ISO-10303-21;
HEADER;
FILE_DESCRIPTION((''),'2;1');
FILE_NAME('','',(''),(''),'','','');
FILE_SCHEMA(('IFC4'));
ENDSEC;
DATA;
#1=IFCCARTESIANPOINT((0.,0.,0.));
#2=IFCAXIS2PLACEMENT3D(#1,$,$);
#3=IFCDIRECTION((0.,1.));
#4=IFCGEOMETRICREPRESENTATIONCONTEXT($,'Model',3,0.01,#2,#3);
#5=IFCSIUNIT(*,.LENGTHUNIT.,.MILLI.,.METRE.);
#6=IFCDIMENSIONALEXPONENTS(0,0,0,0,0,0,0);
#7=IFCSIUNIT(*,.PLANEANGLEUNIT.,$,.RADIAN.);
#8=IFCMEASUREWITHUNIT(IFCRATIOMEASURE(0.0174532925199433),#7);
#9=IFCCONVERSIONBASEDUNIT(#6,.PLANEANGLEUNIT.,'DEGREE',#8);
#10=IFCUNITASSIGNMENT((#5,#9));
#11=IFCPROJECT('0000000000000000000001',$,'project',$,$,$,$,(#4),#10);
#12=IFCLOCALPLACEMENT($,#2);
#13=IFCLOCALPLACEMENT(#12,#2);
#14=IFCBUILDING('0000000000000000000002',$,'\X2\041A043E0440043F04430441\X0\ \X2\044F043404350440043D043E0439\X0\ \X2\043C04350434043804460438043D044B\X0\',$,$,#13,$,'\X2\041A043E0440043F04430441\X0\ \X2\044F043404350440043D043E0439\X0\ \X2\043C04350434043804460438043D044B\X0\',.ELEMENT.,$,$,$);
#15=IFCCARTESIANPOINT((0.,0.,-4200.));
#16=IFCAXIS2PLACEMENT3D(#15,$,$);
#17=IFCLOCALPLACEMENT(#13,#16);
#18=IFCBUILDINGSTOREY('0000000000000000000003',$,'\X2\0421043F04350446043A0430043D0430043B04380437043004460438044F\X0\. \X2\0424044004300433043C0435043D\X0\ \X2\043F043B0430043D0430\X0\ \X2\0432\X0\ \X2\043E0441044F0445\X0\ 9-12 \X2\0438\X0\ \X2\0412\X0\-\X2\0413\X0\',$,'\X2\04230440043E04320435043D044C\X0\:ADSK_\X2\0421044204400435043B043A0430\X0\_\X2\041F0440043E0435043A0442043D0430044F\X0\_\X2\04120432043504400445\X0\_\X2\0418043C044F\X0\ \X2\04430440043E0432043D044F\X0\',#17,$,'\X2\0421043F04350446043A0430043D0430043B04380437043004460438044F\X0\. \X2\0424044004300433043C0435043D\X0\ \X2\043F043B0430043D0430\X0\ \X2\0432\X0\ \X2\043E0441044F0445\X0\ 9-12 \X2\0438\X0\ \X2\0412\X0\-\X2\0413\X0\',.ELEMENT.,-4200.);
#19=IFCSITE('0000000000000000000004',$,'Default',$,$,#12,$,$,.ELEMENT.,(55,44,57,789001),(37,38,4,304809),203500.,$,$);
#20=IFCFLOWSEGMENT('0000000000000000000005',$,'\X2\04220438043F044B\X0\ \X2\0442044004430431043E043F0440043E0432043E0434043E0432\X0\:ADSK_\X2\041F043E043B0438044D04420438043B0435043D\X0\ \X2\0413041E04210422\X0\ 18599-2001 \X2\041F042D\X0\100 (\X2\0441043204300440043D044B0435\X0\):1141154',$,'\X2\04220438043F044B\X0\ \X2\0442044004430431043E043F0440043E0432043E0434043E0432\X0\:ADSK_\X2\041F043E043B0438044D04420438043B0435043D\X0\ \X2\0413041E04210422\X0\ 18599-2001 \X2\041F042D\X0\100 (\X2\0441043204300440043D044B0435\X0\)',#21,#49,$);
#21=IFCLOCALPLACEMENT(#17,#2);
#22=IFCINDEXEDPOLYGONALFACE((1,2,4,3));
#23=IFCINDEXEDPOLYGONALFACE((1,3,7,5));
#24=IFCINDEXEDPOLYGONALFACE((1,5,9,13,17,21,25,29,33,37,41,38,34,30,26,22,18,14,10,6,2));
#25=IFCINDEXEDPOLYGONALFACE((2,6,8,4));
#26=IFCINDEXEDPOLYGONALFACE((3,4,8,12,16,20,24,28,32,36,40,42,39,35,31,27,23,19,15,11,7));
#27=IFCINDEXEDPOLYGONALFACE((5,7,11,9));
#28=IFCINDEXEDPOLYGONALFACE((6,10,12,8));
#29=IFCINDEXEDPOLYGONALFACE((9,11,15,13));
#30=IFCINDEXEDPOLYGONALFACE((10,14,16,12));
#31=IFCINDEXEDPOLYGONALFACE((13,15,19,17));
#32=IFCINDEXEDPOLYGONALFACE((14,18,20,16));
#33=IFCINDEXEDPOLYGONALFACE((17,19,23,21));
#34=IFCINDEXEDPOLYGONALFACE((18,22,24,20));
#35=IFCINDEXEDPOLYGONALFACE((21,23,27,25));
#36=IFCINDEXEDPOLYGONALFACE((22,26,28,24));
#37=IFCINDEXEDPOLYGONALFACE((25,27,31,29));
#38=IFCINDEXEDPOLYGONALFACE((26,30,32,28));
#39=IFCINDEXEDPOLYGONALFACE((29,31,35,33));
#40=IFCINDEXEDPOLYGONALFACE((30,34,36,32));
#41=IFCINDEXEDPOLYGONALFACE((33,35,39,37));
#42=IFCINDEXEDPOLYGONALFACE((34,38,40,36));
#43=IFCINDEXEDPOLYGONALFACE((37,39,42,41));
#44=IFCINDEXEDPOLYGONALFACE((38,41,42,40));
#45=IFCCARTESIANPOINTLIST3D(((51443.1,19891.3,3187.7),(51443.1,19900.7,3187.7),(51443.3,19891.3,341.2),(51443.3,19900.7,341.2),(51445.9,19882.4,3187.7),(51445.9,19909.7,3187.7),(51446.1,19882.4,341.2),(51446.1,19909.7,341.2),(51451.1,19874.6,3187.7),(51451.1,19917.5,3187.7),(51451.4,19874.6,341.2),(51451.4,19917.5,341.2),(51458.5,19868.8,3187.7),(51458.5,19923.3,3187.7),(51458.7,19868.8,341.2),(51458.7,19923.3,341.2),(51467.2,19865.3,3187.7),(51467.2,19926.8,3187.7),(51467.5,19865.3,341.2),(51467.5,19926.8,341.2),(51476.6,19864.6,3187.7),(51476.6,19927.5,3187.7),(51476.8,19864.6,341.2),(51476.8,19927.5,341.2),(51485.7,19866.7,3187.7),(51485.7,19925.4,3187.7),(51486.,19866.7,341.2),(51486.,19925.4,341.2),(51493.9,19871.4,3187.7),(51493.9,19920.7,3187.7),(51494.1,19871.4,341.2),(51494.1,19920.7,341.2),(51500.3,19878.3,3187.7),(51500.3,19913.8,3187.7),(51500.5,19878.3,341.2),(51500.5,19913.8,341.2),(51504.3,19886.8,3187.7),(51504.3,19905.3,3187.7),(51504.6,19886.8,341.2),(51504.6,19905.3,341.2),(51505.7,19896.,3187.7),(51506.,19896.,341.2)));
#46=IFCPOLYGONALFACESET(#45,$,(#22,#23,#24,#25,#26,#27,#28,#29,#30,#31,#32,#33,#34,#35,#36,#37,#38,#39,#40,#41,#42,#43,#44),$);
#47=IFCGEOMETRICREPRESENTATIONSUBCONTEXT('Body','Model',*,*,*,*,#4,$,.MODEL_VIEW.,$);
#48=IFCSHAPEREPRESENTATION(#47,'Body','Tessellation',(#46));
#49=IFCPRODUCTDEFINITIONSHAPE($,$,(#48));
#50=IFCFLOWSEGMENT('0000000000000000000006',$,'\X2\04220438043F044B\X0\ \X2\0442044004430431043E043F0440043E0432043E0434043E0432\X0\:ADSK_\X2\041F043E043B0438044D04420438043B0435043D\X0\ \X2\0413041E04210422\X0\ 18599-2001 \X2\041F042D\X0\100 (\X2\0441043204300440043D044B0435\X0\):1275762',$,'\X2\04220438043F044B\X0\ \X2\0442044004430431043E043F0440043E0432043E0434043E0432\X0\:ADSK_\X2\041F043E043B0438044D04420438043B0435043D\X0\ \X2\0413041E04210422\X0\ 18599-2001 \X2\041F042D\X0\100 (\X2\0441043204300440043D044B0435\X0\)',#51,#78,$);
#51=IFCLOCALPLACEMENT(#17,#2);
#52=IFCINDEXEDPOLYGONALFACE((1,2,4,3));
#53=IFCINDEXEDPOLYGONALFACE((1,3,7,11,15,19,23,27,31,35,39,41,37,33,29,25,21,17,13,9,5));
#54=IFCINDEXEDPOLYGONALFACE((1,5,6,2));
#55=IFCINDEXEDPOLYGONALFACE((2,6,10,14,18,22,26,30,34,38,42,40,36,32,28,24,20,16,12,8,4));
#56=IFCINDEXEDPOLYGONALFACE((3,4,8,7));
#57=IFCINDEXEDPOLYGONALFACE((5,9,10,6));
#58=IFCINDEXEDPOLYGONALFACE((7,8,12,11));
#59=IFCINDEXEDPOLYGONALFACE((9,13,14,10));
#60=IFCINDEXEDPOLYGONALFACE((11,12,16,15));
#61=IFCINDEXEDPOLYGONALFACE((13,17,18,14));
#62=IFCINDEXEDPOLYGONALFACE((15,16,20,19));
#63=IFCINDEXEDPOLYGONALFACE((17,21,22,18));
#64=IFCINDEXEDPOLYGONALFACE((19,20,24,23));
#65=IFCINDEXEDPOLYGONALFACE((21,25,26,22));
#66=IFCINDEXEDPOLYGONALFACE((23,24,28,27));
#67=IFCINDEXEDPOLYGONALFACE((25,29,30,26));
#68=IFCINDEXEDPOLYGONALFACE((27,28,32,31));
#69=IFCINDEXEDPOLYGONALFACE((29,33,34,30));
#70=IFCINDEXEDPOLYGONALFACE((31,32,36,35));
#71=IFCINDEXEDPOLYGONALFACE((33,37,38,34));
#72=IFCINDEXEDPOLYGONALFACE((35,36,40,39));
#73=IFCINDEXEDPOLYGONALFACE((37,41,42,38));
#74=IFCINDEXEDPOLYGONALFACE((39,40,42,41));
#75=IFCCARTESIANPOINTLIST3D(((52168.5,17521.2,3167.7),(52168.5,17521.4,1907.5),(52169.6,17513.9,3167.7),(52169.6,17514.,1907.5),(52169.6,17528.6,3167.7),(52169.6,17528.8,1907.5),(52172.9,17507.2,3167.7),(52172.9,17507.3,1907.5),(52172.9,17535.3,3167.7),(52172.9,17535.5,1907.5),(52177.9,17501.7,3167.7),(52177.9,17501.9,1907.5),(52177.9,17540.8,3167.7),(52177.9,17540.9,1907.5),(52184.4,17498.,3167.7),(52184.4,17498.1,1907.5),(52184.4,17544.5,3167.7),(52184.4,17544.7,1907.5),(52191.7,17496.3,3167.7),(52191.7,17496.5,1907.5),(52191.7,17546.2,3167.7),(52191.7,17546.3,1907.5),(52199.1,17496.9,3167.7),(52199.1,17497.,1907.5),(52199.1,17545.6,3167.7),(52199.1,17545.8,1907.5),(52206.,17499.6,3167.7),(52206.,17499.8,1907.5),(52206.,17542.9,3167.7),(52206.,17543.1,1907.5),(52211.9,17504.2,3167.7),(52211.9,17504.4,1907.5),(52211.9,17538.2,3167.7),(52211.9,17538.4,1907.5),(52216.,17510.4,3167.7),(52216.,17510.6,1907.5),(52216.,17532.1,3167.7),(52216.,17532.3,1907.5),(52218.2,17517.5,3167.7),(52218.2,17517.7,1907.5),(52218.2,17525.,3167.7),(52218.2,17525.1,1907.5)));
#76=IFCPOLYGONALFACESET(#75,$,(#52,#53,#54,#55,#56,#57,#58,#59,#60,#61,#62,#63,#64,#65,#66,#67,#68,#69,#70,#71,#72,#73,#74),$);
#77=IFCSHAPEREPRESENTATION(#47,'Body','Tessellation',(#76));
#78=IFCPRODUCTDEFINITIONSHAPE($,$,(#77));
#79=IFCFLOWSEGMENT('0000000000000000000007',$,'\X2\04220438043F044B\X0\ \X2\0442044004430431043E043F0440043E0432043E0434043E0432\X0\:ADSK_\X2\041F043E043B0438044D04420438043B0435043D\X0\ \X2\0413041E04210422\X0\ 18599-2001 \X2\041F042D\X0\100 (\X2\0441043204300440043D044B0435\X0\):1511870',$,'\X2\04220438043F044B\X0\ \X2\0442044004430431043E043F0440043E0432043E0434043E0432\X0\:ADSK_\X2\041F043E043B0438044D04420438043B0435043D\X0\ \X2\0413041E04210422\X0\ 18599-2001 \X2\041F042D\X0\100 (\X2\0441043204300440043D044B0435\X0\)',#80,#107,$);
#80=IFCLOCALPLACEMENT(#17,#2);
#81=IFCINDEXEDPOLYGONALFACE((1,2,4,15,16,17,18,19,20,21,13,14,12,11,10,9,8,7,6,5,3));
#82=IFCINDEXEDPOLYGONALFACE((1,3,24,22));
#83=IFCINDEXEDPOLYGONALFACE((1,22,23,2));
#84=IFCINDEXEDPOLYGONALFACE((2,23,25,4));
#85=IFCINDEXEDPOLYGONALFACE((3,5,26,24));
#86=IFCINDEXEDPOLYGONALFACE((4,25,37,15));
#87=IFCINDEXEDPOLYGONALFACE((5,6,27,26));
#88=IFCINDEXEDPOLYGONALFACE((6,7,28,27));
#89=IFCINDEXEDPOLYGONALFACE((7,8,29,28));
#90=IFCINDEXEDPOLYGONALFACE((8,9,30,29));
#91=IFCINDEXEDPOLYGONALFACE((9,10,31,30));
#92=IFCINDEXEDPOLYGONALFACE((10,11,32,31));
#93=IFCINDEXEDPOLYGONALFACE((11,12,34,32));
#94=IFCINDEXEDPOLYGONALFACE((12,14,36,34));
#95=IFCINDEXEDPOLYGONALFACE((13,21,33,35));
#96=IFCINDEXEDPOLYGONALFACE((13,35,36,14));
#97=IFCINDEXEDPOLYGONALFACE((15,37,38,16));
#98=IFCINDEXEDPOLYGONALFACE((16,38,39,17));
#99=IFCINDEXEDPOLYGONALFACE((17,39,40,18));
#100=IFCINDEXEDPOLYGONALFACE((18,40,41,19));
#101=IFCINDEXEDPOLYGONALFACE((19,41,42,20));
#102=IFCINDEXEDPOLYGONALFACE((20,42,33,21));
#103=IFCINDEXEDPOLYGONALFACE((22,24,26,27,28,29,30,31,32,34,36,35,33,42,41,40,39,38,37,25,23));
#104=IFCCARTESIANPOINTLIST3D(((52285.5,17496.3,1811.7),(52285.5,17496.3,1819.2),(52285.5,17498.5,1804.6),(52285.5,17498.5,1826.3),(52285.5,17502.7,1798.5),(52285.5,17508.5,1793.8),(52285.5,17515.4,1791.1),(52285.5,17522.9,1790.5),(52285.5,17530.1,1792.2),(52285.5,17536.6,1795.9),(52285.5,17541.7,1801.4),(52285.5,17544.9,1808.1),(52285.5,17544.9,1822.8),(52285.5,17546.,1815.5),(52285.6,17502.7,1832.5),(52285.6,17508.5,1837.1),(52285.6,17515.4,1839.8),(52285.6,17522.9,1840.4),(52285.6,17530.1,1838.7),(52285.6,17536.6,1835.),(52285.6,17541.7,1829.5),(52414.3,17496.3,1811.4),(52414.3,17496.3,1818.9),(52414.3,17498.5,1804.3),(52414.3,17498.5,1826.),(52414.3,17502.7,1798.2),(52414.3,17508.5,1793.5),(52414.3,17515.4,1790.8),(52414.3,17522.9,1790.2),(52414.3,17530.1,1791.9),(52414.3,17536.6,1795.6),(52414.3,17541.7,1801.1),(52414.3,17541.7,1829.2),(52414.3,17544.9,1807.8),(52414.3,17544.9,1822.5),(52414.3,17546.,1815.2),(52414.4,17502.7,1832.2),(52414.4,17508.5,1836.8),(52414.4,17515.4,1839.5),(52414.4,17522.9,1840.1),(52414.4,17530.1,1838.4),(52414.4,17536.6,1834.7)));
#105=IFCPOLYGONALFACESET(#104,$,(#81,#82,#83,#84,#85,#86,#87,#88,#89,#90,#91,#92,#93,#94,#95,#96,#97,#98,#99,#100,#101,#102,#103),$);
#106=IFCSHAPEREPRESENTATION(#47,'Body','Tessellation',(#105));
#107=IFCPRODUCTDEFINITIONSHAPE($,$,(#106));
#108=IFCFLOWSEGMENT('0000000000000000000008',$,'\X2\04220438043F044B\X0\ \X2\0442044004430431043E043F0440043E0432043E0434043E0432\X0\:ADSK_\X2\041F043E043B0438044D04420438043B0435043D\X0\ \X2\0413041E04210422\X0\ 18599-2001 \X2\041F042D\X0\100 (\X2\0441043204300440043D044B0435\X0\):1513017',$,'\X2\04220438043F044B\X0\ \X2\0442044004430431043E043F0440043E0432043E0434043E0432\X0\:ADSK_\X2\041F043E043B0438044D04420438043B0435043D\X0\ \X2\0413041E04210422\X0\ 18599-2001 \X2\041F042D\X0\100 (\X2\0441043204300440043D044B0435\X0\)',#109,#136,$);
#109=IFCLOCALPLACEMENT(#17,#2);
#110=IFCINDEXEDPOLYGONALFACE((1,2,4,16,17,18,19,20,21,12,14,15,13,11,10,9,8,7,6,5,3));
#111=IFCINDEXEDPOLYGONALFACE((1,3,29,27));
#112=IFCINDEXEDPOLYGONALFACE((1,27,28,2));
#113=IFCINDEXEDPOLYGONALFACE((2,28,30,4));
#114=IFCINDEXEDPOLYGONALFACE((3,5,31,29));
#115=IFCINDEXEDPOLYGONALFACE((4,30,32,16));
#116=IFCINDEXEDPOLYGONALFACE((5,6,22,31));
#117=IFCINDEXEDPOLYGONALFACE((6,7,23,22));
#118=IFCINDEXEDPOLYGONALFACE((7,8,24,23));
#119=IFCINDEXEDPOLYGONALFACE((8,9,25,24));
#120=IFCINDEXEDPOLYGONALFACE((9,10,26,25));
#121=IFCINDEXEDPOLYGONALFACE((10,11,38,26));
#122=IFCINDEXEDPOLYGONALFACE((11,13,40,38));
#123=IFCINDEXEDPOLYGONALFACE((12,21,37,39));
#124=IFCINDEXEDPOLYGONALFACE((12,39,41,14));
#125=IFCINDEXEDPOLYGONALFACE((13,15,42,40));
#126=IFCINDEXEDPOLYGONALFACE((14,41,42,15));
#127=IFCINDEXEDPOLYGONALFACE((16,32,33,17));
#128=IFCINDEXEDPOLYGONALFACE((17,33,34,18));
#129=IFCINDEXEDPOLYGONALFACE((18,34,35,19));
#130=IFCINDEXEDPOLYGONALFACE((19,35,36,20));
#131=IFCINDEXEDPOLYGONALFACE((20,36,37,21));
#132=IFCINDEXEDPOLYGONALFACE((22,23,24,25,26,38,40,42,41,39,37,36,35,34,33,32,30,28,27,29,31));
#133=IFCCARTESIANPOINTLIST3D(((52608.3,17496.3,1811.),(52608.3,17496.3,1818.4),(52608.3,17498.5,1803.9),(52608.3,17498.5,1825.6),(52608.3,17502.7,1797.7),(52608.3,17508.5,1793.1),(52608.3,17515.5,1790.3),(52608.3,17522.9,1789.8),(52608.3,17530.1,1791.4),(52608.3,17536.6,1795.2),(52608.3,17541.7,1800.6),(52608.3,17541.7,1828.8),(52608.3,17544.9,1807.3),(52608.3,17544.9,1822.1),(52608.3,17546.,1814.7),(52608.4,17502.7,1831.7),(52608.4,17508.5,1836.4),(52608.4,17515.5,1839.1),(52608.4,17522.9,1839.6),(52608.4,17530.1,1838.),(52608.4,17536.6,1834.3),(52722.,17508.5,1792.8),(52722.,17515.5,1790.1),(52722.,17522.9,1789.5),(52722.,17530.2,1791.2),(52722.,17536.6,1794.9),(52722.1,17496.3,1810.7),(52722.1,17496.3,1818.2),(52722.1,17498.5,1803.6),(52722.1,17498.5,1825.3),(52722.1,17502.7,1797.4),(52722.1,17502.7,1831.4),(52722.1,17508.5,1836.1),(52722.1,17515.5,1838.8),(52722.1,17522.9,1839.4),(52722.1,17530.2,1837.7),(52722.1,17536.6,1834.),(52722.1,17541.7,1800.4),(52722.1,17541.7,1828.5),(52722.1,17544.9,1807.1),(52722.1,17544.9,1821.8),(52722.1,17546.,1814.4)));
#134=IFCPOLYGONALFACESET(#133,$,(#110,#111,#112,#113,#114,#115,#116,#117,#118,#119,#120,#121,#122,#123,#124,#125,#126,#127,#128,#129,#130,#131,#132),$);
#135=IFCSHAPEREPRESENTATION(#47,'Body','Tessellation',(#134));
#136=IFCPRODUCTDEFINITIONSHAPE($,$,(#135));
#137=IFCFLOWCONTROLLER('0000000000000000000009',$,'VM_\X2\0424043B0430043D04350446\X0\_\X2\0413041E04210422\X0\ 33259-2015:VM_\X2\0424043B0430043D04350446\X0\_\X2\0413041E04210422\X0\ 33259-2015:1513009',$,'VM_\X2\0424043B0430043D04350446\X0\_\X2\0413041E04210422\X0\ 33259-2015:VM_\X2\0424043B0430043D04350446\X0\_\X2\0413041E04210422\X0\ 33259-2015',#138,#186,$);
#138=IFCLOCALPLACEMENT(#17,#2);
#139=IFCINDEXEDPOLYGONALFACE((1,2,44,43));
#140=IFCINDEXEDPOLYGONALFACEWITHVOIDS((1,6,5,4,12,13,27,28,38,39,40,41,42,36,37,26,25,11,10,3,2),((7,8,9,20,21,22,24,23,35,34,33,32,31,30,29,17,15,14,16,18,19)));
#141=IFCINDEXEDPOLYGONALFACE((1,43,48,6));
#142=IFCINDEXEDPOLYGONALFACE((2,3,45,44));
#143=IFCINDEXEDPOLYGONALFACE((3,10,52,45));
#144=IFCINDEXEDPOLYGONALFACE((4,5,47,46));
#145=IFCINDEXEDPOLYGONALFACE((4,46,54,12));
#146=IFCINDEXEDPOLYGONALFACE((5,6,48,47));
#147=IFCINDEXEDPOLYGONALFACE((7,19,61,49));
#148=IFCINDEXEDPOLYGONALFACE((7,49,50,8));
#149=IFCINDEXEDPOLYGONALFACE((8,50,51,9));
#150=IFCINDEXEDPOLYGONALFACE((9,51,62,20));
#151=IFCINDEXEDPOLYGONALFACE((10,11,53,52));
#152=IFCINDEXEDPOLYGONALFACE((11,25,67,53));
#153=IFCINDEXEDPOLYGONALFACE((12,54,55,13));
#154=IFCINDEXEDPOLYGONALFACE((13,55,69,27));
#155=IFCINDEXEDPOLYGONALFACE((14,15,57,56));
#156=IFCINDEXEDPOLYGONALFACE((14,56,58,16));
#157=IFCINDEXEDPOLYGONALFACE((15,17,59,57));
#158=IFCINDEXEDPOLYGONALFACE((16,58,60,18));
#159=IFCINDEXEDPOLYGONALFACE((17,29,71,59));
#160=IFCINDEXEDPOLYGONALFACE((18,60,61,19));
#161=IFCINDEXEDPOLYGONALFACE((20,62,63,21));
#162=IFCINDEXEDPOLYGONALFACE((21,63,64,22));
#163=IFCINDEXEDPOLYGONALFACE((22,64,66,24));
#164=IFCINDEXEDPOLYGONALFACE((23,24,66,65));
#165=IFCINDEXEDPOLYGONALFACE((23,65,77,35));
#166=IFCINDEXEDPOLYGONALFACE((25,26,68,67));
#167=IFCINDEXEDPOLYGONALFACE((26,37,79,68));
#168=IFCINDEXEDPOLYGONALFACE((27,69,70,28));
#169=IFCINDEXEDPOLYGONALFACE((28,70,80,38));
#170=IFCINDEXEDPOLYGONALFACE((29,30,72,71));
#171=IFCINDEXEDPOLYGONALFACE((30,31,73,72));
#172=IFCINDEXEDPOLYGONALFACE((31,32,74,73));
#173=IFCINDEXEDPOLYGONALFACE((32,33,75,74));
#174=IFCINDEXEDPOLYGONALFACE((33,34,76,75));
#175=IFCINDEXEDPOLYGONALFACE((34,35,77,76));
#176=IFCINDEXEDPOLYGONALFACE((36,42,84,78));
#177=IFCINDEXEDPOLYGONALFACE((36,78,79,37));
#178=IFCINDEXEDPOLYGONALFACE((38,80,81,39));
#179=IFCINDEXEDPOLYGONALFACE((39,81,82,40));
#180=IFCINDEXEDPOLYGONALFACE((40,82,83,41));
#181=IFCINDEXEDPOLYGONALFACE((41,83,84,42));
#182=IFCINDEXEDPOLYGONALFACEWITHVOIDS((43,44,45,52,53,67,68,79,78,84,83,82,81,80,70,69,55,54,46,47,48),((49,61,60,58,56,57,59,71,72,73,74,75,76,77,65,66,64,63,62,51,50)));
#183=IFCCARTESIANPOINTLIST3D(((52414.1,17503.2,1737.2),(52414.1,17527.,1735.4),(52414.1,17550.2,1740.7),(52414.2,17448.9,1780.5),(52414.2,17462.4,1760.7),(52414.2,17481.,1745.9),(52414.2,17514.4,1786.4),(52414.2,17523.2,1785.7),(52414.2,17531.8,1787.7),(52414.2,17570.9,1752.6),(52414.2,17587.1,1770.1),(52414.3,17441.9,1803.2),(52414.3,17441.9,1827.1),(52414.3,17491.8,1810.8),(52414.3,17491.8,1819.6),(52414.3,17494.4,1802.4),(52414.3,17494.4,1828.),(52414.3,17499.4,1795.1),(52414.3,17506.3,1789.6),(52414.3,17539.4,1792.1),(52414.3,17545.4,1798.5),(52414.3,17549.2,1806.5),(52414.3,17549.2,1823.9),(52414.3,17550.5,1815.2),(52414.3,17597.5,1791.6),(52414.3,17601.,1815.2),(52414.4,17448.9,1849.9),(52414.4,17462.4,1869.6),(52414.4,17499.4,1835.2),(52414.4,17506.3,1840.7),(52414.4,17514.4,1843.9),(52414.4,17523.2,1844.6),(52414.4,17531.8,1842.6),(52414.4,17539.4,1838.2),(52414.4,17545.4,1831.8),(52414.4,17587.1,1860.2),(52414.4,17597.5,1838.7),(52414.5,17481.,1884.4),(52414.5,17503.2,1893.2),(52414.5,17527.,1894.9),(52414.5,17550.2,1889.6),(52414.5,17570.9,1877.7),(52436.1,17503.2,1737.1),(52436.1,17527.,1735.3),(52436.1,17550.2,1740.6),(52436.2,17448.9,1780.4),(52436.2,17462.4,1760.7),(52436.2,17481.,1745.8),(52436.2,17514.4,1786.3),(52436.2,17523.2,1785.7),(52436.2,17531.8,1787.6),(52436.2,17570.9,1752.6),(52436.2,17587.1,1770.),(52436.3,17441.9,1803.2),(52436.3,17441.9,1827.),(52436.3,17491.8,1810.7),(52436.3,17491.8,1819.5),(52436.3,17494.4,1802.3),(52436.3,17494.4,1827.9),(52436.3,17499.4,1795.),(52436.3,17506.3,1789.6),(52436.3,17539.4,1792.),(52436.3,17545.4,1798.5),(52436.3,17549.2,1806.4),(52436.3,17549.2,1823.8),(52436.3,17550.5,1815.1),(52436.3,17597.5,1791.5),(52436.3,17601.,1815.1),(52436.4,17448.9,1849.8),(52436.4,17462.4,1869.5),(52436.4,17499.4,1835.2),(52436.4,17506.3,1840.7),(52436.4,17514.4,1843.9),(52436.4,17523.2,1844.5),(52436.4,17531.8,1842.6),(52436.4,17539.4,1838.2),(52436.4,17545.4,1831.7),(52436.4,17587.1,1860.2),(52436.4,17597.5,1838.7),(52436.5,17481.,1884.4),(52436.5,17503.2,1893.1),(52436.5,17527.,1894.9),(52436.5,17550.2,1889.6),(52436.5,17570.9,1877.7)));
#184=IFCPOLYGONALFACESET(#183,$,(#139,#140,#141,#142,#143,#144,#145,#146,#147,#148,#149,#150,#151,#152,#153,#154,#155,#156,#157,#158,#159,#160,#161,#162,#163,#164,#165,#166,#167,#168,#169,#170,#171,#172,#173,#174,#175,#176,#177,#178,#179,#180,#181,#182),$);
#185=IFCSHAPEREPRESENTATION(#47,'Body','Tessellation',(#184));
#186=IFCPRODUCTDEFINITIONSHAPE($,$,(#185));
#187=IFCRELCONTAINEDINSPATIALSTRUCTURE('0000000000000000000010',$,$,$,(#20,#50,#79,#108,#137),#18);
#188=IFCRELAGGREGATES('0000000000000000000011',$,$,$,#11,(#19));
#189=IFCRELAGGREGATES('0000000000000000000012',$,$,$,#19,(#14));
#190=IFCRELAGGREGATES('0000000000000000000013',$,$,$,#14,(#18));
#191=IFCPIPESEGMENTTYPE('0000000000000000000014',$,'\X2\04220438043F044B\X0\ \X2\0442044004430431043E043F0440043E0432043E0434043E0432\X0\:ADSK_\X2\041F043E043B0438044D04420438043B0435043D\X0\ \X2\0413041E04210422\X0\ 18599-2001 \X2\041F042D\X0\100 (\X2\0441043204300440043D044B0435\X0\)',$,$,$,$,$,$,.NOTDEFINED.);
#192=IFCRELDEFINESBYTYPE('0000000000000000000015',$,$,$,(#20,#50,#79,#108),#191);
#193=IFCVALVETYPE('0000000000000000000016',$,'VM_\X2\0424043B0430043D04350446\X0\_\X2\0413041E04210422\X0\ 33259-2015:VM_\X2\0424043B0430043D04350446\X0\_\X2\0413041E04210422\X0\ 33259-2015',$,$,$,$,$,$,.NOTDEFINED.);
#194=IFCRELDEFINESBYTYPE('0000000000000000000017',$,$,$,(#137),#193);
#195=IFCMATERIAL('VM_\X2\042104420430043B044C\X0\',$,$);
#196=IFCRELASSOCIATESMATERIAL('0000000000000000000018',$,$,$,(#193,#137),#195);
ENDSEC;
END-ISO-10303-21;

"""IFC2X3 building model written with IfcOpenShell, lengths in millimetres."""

from ifc_helpers import new_model, entity, si_unit, converted_unit, direction, frame, frame_2d, origin, origin_2d_with_axis, place, context, subcontext, project, spatial, circle, hollow_circle, extrude, source, transform, mapped, material, type_object, type_shapes, element, save


model = new_model("IFC2X3")

# Units and contexts
model_context = context("Model", 3, precision=0.01, world=origin(), true_north=direction((0.0, 1.0)))
body_context = subcontext(model_context, "Body", "Model", "MODEL_VIEW")
ifc_project = project(units=[si_unit("LENGTHUNIT", "METRE", prefix="MILLI"), converted_unit("PLANEANGLEUNIT", "DEGREE", entity("IfcRatioMeasure", 0.0174532925199433), si_unit("PLANEANGLEUNIT", "RADIAN"), dimensions=[0, 0, 0, 0, 0, 0, 0])], contexts=[model_context])

# Site, building, storey
site_placement = place(None, frame((0.0, 0.0, 0.0)))
site = spatial("IfcSite", under=ifc_project, at=site_placement, Name="Default", CompositionType="ELEMENT", RefLatitude=(55, 44, 57, 789001), RefLongitude=(37, 38, 4, 304809), RefElevation=203500.0)
building_placement = place(site_placement, origin())
building = spatial("IfcBuilding", under=site, at=building_placement, Name="Корпус ядерной медицины", LongName="Корпус ядерной медицины", CompositionType="ELEMENT")
storey_placement = place(building_placement, frame((0.0, 0.0, -4200.0)))
storey = spatial("IfcBuildingStorey", under=building, at=storey_placement, Name="Спецканализация. Фрагмен плана в осях 9-12 и В-Г", ObjectType="Уровень:ADSK_Стрелка_Проектная_Вверх_Имя уровня", LongName="Спецканализация. Фрагмен плана в осях 9-12 и В-Г", CompositionType="ELEMENT", Elevation=-4200.0)

# Flow segments
pipe_segment_type = type_object("IfcPipeSegmentType", Name="Типы трубопроводов:ADSK_Полиэтилен ГОСТ 18599-2001 ПЭ100 (сварные)", PredefinedType="NOTDEFINED")
flow_segment_1_placement = place(storey_placement, frame((51441.1, 19862.9, 341.2)))
element("IfcFlowSegment", 1, at=flow_segment_1_placement, inside=storey, type_object=pipe_segment_type, Name="Типы трубопроводов:ADSK_Полиэтилен ГОСТ 18599-2001 ПЭ100 (сварные):1141154", ObjectType="Типы трубопроводов:ADSK_Полиэтилен ГОСТ 18599-2001 ПЭ100 (сварные)", context=body_context, shape_type="SweptSolid", body=[
    extrude(circle(Radius=31.5, at=origin_2d_with_axis()), frame((33.3, 33.1, 0.0), z_axis=(-0.00008, 0.0, 1.0), x_axis=(1.0, 0.0, 0.00008)), (0.0, 0.0, 1.0), 2846.4),
])
flow_segment_2_placement = place(storey_placement, frame((52166.9, 17494.6, 1907.5)))
element("IfcFlowSegment", 2, at=flow_segment_2_placement, inside=storey, type_object=pipe_segment_type, Name="Типы трубопроводов:ADSK_Полиэтилен ГОСТ 18599-2001 ПЭ100 (сварные):1275762", ObjectType="Типы трубопроводов:ADSK_Полиэтилен ГОСТ 18599-2001 ПЭ100 (сварные)", context=body_context, shape_type="SweptSolid", body=[
    extrude(circle(Radius=25.0, at=origin_2d_with_axis()), frame((26.6, 26.8, 0.0), z_axis=(0.000001, -0.00013, 1.0), x_axis=(-1.0, 0.0, 0.000001)), (0.0, 0.0, 1.0), 1260.3),
])
flow_segment_3_placement = place(storey_placement, frame((52285.5, 17494.4, 1788.6)))
element("IfcFlowSegment", 3, at=flow_segment_3_placement, inside=storey, type_object=pipe_segment_type, Name="Типы трубопроводов:ADSK_Полиэтилен ГОСТ 18599-2001 ПЭ100 (сварные):1511870", ObjectType="Типы трубопроводов:ADSK_Полиэтилен ГОСТ 18599-2001 ПЭ100 (сварные)", context=body_context, shape_type="SweptSolid", body=[
    extrude(circle(Radius=25.0, at=frame_2d((0.0, 0.0), x_axis=(1.0, 0.0))), frame((0.1, 26.6, 26.9), z_axis=(0.999997, 0.000027, -0.002338), x_axis=(-0.000027, 1.0, 0.0)), (0.0, 0.0, 1.0), 128.8),
])
flow_segment_4_placement = place(storey_placement, frame((52608.3, 17494.4, 1787.8)))
element("IfcFlowSegment", 4, at=flow_segment_4_placement, inside=storey, type_object=pipe_segment_type, Name="Типы трубопроводов:ADSK_Полиэтилен ГОСТ 18599-2001 ПЭ100 (сварные):1513017", ObjectType="Типы трубопроводов:ADSK_Полиэтилен ГОСТ 18599-2001 ПЭ100 (сварные)", context=body_context, shape_type="SweptSolid", body=[
    extrude(circle(Radius=25.0, at=frame_2d((0.0, 0.0), x_axis=(1.0, 0.0))), frame((0.1, 26.6, 26.9), z_axis=(0.999997, 0.000027, -0.002338), x_axis=(-0.000027, 1.0, 0.0)), (0.0, 0.0, 1.0), 113.8),
])

# Flow controller
ifc_material_1 = material(Name="VM_Сталь")
valve_type_1 = type_object("IfcValveType", Name="VM_Фланец_ГОСТ 33259-2015:VM_Фланец_ГОСТ 33259-2015", PredefinedType="NOTDEFINED", material=ifc_material_1)
shared_shape_1 = source(origin(), body_context, "Body", "SweptSolid", [
    extrude(hollow_circle(Radius=80.0, WallThickness=50.5, at=frame_2d((0.0, 0.0), x_axis=(1.0, 0.0))), frame((0.0, 0.0, 0.0), z_axis=(1.0, 0.0, 0.0), x_axis=(0.0, 1.0, 0.0)), (0.0, 0.0, 1.0), 22.0),
])
type_shapes(valve_type_1, [shared_shape_1])
for number, where, z_axis, x_axis, name in (
    (5, (52414.3, 17521.0, 1815.2), (0.002338, 0.0, 0.999997), (0.999997, 0.000027, -0.002338), "VM_Фланец_ГОСТ 33259-2015:VM_Фланец_ГОСТ 33259-2015:1513009"),
):
    element("IfcFlowController", number, at=place(storey_placement, frame(where, z_axis=z_axis, x_axis=x_axis)), inside=storey, type_object=valve_type_1, material=ifc_material_1, Name=name, ObjectType="VM_Фланец_ГОСТ 33259-2015:VM_Фланец_ГОСТ 33259-2015", context=body_context, shape_type="MappedRepresentation", body=[
        mapped(shared_shape_1, transform((0.0, 0.0, 0.0), scale=1.0)),
    ])

save(model, "model.ifc")
